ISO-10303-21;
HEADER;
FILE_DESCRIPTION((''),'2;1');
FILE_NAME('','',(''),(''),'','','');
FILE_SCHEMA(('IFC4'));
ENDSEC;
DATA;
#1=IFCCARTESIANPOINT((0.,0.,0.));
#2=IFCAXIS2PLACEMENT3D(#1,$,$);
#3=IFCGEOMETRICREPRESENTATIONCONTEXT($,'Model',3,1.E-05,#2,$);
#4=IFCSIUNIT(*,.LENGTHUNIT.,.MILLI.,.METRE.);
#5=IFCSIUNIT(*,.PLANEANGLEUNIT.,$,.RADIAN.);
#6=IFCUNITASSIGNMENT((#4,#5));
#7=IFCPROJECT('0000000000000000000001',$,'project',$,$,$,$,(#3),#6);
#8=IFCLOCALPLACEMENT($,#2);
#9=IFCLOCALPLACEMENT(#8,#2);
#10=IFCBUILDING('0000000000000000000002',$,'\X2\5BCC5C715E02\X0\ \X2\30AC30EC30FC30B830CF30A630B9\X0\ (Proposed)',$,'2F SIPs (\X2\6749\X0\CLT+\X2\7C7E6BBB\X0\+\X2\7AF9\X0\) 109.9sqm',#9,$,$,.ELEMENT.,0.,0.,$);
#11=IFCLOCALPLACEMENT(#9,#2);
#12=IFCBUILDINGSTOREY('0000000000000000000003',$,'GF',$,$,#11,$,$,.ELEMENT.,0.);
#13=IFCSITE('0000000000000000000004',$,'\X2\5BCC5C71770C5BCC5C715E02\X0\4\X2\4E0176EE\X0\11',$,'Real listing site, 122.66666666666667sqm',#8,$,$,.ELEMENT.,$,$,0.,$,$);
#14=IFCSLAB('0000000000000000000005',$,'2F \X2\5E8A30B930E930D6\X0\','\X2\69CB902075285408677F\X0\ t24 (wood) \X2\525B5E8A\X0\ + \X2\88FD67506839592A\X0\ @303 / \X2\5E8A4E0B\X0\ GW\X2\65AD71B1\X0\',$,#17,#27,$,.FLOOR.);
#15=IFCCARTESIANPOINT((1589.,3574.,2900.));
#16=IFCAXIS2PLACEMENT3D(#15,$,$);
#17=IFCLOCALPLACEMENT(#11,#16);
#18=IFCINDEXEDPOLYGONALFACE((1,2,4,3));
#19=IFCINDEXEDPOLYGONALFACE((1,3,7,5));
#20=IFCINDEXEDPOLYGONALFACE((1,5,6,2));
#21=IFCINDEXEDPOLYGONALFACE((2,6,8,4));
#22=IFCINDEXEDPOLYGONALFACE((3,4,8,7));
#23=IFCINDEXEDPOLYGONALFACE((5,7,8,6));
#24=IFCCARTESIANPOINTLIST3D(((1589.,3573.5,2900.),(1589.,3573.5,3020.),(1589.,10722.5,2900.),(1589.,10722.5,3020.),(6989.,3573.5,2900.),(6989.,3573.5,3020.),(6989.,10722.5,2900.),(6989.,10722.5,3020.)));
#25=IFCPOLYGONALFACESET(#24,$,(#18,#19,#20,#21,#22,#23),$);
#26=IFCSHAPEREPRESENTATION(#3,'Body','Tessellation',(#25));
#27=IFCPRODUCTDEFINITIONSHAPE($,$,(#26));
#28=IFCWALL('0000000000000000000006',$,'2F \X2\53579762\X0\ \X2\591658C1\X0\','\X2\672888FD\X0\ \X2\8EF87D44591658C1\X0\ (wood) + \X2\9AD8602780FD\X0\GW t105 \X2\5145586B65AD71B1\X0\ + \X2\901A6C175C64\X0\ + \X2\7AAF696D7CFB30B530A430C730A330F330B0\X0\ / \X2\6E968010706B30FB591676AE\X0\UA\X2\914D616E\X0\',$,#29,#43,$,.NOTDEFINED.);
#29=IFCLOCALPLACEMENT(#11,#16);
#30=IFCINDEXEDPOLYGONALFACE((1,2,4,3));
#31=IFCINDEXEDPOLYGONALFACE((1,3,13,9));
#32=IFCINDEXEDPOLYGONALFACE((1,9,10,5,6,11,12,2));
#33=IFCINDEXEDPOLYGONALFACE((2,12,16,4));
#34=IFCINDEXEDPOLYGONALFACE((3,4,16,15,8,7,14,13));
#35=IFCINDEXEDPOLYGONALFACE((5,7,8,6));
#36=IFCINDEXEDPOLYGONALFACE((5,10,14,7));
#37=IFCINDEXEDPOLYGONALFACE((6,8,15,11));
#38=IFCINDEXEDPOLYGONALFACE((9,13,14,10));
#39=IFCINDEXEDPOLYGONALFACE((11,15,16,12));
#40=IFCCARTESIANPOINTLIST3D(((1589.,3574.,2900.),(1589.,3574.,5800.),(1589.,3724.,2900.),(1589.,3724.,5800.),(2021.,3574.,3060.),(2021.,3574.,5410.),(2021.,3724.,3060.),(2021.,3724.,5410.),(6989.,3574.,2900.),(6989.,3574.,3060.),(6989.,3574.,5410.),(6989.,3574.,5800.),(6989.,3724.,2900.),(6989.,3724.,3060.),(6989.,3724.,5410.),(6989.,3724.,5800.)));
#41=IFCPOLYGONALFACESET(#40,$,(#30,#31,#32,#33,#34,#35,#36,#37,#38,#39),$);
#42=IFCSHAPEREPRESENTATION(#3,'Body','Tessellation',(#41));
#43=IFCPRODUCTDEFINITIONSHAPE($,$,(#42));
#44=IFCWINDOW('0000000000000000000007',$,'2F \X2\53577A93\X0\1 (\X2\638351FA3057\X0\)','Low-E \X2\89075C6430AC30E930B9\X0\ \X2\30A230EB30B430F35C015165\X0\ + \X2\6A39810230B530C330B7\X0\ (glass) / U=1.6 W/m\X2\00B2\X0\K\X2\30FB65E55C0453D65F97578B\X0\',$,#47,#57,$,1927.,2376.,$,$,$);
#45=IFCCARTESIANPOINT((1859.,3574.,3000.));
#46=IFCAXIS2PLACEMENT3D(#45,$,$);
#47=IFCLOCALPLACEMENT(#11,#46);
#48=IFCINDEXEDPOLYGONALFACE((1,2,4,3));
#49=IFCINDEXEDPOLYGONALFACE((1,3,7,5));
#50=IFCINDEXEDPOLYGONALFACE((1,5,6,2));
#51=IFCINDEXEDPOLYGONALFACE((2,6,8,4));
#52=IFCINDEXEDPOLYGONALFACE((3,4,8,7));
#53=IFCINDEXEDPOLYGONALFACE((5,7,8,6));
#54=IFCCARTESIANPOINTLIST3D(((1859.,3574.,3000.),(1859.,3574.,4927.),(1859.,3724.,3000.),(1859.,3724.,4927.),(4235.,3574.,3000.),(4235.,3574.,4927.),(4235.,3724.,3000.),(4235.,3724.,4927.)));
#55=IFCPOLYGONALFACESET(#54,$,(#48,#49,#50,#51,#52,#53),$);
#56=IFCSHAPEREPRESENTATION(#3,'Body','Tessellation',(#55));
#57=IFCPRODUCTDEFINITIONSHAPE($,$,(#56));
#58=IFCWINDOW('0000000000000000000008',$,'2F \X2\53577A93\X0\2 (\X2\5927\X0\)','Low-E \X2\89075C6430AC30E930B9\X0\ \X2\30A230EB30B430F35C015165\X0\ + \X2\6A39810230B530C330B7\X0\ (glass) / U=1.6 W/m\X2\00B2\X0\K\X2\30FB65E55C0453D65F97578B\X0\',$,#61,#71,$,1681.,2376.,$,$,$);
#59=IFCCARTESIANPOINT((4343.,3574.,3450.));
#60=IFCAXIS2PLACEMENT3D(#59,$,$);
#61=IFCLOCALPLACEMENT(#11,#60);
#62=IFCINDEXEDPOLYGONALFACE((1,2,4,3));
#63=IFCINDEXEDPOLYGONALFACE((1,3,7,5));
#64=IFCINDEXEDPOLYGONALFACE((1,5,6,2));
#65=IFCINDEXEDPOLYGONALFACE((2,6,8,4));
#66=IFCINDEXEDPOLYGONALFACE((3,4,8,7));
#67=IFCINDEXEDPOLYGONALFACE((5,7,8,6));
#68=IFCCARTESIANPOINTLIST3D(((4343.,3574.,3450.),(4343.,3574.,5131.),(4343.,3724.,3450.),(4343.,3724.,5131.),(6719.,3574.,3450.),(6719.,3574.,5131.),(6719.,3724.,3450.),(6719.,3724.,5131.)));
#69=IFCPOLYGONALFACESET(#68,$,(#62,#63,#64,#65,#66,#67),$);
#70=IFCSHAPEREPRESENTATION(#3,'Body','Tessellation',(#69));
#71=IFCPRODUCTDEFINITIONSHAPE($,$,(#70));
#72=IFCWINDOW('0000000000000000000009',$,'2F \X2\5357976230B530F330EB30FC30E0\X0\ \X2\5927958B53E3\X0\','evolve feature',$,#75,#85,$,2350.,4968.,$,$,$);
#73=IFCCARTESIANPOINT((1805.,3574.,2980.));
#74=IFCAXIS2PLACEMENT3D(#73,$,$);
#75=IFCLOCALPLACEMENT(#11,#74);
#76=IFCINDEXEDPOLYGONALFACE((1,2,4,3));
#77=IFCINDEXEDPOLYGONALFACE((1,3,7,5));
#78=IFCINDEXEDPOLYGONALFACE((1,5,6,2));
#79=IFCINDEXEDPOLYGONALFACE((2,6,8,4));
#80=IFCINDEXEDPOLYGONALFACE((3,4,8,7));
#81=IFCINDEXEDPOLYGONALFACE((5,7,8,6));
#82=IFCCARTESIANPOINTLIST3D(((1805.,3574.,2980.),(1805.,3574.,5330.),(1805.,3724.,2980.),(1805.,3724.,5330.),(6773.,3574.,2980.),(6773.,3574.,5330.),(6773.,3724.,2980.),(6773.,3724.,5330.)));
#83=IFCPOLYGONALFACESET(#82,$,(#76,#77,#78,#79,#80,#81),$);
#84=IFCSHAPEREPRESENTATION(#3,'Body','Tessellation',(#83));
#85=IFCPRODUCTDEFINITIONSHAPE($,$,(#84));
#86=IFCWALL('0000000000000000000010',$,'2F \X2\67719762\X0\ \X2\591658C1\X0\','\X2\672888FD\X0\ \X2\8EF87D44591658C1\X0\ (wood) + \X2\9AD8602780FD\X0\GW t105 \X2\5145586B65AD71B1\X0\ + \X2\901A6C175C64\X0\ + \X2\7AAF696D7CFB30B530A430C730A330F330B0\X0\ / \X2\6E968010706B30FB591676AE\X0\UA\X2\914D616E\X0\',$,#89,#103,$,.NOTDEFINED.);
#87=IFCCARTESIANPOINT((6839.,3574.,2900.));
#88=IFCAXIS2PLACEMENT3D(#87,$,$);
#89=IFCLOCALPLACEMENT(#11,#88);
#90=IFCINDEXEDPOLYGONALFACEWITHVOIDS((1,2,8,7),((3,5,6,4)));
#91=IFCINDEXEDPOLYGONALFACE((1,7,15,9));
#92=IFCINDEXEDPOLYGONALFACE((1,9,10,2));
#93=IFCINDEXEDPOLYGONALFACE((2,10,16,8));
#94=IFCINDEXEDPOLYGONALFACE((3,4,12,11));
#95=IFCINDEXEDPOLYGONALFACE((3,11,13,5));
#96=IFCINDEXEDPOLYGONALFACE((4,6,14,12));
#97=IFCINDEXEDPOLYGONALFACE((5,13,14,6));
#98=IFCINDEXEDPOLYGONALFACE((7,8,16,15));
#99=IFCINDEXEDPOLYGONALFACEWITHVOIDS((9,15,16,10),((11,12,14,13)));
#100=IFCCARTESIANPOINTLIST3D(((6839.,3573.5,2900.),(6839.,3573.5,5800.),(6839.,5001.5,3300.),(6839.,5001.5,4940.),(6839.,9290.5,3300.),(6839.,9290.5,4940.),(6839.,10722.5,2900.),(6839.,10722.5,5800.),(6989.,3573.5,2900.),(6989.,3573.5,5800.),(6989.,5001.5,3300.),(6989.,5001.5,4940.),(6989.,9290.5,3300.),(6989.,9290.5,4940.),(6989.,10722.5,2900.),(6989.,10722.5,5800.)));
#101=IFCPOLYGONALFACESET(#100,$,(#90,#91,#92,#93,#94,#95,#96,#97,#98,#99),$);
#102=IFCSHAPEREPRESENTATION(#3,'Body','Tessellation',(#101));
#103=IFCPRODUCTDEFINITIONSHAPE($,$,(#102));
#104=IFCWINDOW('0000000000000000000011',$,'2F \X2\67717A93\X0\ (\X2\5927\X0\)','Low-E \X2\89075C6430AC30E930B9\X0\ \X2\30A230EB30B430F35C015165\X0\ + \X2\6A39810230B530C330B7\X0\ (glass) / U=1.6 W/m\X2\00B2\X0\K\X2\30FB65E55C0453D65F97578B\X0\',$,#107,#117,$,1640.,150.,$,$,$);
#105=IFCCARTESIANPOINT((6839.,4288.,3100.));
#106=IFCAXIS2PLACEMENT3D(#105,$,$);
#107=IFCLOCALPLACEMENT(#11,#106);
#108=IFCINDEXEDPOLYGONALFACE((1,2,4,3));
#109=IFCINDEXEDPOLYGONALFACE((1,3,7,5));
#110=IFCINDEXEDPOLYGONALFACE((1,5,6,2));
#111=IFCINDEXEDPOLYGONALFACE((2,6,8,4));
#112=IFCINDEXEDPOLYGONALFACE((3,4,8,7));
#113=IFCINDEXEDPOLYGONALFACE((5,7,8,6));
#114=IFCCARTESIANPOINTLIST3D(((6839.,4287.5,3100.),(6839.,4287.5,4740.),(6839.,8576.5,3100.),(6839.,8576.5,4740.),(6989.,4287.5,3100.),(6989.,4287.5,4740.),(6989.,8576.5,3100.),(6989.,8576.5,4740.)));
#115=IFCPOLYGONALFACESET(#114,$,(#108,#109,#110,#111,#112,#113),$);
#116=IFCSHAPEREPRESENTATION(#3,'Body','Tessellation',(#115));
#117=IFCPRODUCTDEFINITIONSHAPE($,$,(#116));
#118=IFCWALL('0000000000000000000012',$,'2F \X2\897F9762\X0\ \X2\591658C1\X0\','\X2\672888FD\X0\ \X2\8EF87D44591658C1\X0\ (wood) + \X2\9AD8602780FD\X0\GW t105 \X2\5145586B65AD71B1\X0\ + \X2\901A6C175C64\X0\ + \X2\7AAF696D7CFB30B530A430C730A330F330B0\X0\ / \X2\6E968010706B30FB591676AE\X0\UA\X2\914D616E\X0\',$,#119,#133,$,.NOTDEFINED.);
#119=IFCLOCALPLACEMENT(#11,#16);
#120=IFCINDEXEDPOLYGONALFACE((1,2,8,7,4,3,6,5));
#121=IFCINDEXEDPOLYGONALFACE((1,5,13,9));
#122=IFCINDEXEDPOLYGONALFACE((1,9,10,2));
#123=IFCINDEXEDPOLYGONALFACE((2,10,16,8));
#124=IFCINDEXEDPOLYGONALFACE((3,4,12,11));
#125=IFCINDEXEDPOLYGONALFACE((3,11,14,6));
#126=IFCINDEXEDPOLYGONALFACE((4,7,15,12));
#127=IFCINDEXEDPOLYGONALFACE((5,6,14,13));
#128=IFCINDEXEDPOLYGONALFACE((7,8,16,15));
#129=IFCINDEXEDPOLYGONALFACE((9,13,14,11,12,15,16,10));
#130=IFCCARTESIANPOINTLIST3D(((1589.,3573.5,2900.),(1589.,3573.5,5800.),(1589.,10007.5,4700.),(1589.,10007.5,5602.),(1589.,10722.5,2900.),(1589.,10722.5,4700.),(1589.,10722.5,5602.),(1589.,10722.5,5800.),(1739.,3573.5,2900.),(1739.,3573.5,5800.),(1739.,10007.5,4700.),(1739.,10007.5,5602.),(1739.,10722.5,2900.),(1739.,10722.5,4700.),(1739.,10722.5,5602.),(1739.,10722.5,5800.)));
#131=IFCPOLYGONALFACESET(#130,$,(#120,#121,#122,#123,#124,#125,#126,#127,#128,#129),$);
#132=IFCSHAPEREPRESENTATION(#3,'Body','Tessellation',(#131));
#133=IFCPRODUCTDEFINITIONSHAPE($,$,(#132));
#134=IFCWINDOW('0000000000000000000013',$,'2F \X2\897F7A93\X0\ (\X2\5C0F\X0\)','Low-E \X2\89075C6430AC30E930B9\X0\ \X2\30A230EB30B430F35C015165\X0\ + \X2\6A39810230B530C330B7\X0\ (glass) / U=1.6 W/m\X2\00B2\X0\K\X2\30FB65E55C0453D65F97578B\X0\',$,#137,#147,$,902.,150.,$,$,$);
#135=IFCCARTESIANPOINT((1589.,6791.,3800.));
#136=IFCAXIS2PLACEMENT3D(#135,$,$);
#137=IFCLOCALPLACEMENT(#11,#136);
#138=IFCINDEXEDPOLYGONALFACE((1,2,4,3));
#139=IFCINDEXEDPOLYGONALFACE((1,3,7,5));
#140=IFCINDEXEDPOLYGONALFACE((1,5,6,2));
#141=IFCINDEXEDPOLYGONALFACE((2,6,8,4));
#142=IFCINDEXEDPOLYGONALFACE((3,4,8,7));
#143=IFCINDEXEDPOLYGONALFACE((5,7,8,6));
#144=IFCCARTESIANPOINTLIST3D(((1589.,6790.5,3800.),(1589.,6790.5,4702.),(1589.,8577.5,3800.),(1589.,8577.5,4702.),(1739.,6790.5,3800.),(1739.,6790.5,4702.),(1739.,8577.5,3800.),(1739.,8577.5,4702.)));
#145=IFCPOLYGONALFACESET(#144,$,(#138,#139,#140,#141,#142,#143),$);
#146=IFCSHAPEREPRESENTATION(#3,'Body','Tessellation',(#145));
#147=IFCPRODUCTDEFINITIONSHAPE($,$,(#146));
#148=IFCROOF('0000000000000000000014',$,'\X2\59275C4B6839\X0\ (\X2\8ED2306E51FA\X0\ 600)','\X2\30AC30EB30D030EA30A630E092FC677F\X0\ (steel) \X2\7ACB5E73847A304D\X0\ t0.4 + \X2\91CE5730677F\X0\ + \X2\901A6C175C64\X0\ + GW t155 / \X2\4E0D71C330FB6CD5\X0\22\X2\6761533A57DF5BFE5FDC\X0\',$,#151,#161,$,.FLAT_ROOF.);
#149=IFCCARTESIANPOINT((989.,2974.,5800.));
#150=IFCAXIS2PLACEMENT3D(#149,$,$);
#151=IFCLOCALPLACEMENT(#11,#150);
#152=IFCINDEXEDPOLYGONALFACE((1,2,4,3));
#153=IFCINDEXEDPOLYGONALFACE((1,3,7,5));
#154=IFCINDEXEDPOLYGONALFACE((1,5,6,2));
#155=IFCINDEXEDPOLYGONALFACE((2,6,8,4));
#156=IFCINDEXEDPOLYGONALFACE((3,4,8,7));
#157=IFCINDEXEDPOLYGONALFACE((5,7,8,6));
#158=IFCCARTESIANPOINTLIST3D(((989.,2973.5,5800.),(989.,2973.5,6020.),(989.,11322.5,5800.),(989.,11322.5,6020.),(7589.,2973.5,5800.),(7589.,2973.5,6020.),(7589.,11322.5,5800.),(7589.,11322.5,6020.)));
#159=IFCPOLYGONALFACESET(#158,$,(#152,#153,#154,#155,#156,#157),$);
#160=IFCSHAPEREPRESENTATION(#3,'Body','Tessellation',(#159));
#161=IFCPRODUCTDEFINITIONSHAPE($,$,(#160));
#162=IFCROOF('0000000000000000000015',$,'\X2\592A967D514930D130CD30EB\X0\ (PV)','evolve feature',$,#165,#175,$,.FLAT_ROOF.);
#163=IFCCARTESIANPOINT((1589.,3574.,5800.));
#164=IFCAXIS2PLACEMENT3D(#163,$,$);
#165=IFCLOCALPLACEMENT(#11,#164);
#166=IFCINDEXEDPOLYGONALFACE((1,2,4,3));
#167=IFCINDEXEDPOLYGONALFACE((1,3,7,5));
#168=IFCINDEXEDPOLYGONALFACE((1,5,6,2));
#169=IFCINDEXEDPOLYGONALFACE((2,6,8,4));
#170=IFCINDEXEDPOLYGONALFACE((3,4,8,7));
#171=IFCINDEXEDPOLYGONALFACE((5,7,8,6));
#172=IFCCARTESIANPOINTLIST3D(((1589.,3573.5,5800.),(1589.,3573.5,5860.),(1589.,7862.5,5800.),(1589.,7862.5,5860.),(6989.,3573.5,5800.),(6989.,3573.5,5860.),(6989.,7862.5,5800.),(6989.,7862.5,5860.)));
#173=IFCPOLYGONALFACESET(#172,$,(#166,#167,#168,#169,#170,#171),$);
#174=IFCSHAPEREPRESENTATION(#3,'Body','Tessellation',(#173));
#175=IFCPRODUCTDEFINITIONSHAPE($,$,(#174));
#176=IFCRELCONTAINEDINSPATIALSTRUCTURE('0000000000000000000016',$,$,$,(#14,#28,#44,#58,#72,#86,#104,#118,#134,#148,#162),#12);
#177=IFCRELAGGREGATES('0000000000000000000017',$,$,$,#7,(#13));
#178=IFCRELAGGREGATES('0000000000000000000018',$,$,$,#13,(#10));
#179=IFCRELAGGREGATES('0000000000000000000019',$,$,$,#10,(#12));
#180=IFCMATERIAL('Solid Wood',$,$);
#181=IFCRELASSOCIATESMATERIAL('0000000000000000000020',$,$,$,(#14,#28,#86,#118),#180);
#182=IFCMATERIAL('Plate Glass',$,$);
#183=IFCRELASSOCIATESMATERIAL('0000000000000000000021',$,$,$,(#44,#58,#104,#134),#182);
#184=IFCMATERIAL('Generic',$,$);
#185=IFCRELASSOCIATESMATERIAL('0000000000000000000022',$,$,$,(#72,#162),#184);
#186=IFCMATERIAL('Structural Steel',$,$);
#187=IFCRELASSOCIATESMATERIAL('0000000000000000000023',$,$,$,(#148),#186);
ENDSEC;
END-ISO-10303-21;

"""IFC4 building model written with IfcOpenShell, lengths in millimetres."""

from ifc_helpers import new_model, si_unit, frame, frame_2d, origin, place, context, project, spatial, rectangle, extrude, material, element, fill, save


model = new_model("IFC4")

# Units and contexts
model_context = context("Model", 3, precision=1e-05, world=origin())
ifc_project = project(units=[si_unit("LENGTHUNIT", "METRE", prefix="MILLI"), si_unit("PLANEANGLEUNIT", "RADIAN")], contexts=[model_context])

# Site, building, storey
site_placement = place(None, origin())
site = spatial("IfcSite", under=ifc_project, at=site_placement, Name="富山県富山市4丁目11", ObjectType="Real listing site, 122.66666666666667sqm", CompositionType="ELEMENT", RefElevation=0.0)
building_placement = place(site_placement, origin())
building = spatial("IfcBuilding", under=site, at=building_placement, Name="富山市 ガレージハウス (Proposed)", ObjectType="2F SIPs (杉CLT+籾殻+竹) 109.9sqm", CompositionType="ELEMENT", ElevationOfRefHeight=0.0, ElevationOfTerrain=0.0)
storey_placement = place(building_placement, origin())
storey = spatial("IfcBuildingStorey", under=building, at=storey_placement, Name="GF", CompositionType="ELEMENT", Elevation=0.0)

# Slab
ifc_material_1 = material(Name="Solid Wood")
slab_placement = place(storey_placement, frame((1589.0, 3574.0, 2900.0)))
element("IfcSlab", 1, at=slab_placement, inside=storey, material=ifc_material_1, Name="2F 床スラブ", Description="構造用合板 t24 (wood) 剛床 + 製材根太 @303 / 床下 GW断熱", PredefinedType="FLOOR", context=model_context, shape_type="SweptSolid", body=[
    extrude(rectangle(XDim=5400.0, YDim=7149.0, at=frame_2d((2700.0, 3574.0))), frame((1589.0, 3574.0, 2900.0)), (0.0, 0.0, 1.0), 120.0),
])

# Wall, openings, windows
wall_1_placement = place(storey_placement, frame((1589.0, 3574.0, 2900.0)))
wall_1 = element("IfcWall", 2, at=wall_1_placement, inside=storey, material=ifc_material_1, Name="2F 南面 外壁", Description="木製 軸組外壁 (wood) + 高性能GW t105 充填断熱 + 通気層 + 窯業系サイディング / 準耐火・外皮UA配慮", PredefinedType="NOTDEFINED", context=model_context, shape_type="SweptSolid", body=[
    extrude(rectangle(XDim=5400.0, YDim=150.0, at=frame_2d((2700.0, 75.0))), frame((1589.0, 3574.0, 2900.0)), (0.0, 0.0, 1.0), 2900.0),
])
opening_1_placement = place(storey_placement, frame((1859.0, 3574.0, 3000.0)))
opening_1 = element("IfcOpeningElement", 3, at=opening_1_placement, cuts=wall_1, PredefinedType="NOTDEFINED", context=model_context, shape_type="SweptSolid", body=[
    extrude(rectangle(XDim=2376.0, YDim=150.0, at=frame_2d((1188.0, 75.0))), frame((1859.0, 3574.0, 3000.0)), (0.0, 0.0, 1.0), 1927.0),
])
opening_2_placement = place(storey_placement, frame((4343.0, 3574.0, 3450.0)))
opening_2 = element("IfcOpeningElement", 4, at=opening_2_placement, cuts=wall_1, PredefinedType="NOTDEFINED", context=model_context, shape_type="SweptSolid", body=[
    extrude(rectangle(XDim=2376.0, YDim=150.0, at=frame_2d((1188.0, 75.0))), frame((4343.0, 3574.0, 3450.0)), (0.0, 0.0, 1.0), 1681.0),
])
opening_3_placement = place(storey_placement, frame((1805.0, 3574.0, 2980.0)))
opening_3 = element("IfcOpeningElement", 5, at=opening_3_placement, cuts=wall_1, PredefinedType="NOTDEFINED", context=model_context, shape_type="SweptSolid", body=[
    extrude(rectangle(XDim=4968.0, YDim=150.0, at=frame_2d((2484.0, 75.0))), frame((1805.0, 3574.0, 2980.0)), (0.0, 0.0, 1.0), 2350.0),
])
ifc_material_2 = material(Name="Plate Glass")
window_1_placement = place(storey_placement, frame((1859.0, 3574.0, 3000.0)))
window_1 = element("IfcWindow", 6, at=window_1_placement, inside=storey, material=ifc_material_2, Name="2F 南窓1 (掃出し)", Description="Low-E 複層ガラス アルゴン封入 + 樹脂サッシ (glass) / U=1.6 W/m²K・日射取得型", OverallHeight=1927.0, OverallWidth=2376.0, context=model_context, shape_type="SweptSolid", body=[
    extrude(rectangle(XDim=2376.0, YDim=150.0, at=frame_2d((1188.0, 75.0))), frame((1859.0, 3574.0, 3000.0)), (0.0, 0.0, 1.0), 1927.0),
])
fill(opening_1, window_1)
window_2_placement = place(storey_placement, frame((4343.0, 3574.0, 3450.0)))
window_2 = element("IfcWindow", 7, at=window_2_placement, inside=storey, material=ifc_material_2, Name="2F 南窓2 (大)", Description="Low-E 複層ガラス アルゴン封入 + 樹脂サッシ (glass) / U=1.6 W/m²K・日射取得型", OverallHeight=1681.0, OverallWidth=2376.0, context=model_context, shape_type="SweptSolid", body=[
    extrude(rectangle(XDim=2376.0, YDim=150.0, at=frame_2d((1188.0, 75.0))), frame((4343.0, 3574.0, 3450.0)), (0.0, 0.0, 1.0), 1681.0),
])
fill(opening_2, window_2)
ifc_material_3 = material(Name="Generic")
window_3_placement = place(storey_placement, frame((1805.0, 3574.0, 2980.0)))
window_3 = element("IfcWindow", 8, at=window_3_placement, inside=storey, material=ifc_material_3, Name="2F 南面サンルーム 大開口", Description="evolve feature", OverallHeight=2350.0, OverallWidth=4968.0, context=model_context, shape_type="SweptSolid", body=[
    extrude(rectangle(XDim=4968.0, YDim=150.0, at=frame_2d((2484.0, 75.0))), frame((1805.0, 3574.0, 2980.0)), (0.0, 0.0, 1.0), 2350.0),
])
fill(opening_3, window_3)

# Walls, openings, windows
wall_2_placement = place(storey_placement, frame((6839.0, 3574.0, 2900.0)))
wall_2 = element("IfcWall", 9, at=wall_2_placement, inside=storey, material=ifc_material_1, Name="2F 東面 外壁", Description="木製 軸組外壁 (wood) + 高性能GW t105 充填断熱 + 通気層 + 窯業系サイディング / 準耐火・外皮UA配慮", PredefinedType="NOTDEFINED", context=model_context, shape_type="SweptSolid", body=[
    extrude(rectangle(XDim=150.0, YDim=7149.0, at=frame_2d((75.0, 3574.0))), frame((6839.0, 3574.0, 2900.0)), (0.0, 0.0, 1.0), 2900.0),
])
opening_4_placement = place(storey_placement, frame((6839.0, 4288.0, 3100.0)))
opening_4 = element("IfcOpeningElement", 10, at=opening_4_placement, cuts=wall_2, PredefinedType="NOTDEFINED", context=model_context, shape_type="SweptSolid", body=[
    extrude(rectangle(XDim=150.0, YDim=4289.0, at=frame_2d((75.0, 2144.0))), frame((6839.0, 4288.0, 3100.0)), (0.0, 0.0, 1.0), 1640.0),
])
window_4_placement = place(storey_placement, frame((6839.0, 4288.0, 3100.0)))
window_4 = element("IfcWindow", 11, at=window_4_placement, inside=storey, material=ifc_material_2, Name="2F 東窓 (大)", Description="Low-E 複層ガラス アルゴン封入 + 樹脂サッシ (glass) / U=1.6 W/m²K・日射取得型", OverallHeight=1640.0, OverallWidth=150.0, context=model_context, shape_type="SweptSolid", body=[
    extrude(rectangle(XDim=150.0, YDim=4289.0, at=frame_2d((75.0, 2144.0))), frame((6839.0, 4288.0, 3100.0)), (0.0, 0.0, 1.0), 1640.0),
])
fill(opening_4, window_4)
wall_3_placement = place(storey_placement, frame((1589.0, 3574.0, 2900.0)))
wall_3 = element("IfcWall", 12, at=wall_3_placement, inside=storey, material=ifc_material_1, Name="2F 西面 外壁", Description="木製 軸組外壁 (wood) + 高性能GW t105 充填断熱 + 通気層 + 窯業系サイディング / 準耐火・外皮UA配慮", PredefinedType="NOTDEFINED", context=model_context, shape_type="SweptSolid", body=[
    extrude(rectangle(XDim=150.0, YDim=7149.0, at=frame_2d((75.0, 3574.0))), frame((1589.0, 3574.0, 2900.0)), (0.0, 0.0, 1.0), 2900.0),
])
opening_5_placement = place(storey_placement, frame((1589.0, 6791.0, 3800.0)))
opening_5 = element("IfcOpeningElement", 13, at=opening_5_placement, cuts=wall_3, PredefinedType="NOTDEFINED", context=model_context, shape_type="SweptSolid", body=[
    extrude(rectangle(XDim=150.0, YDim=1787.0, at=frame_2d((75.0, 893.0))), frame((1589.0, 6791.0, 3800.0)), (0.0, 0.0, 1.0), 902.0),
])
window_5_placement = place(storey_placement, frame((1589.0, 6791.0, 3800.0)))
window_5 = element("IfcWindow", 14, at=window_5_placement, inside=storey, material=ifc_material_2, Name="2F 西窓 (小)", Description="Low-E 複層ガラス アルゴン封入 + 樹脂サッシ (glass) / U=1.6 W/m²K・日射取得型", OverallHeight=902.0, OverallWidth=150.0, context=model_context, shape_type="SweptSolid", body=[
    extrude(rectangle(XDim=150.0, YDim=1787.0, at=frame_2d((75.0, 893.0))), frame((1589.0, 6791.0, 3800.0)), (0.0, 0.0, 1.0), 902.0),
])
fill(opening_5, window_5)

# Roofs
ifc_material_4 = material(Name="Structural Steel")
roof_1_placement = place(storey_placement, frame((989.0, 2974.0, 5800.0)))
element("IfcRoof", 15, at=roof_1_placement, inside=storey, material=ifc_material_4, Name="大屋根 (軒の出 600)", Description="ガルバリウム鋼板 (steel) 立平葺き t0.4 + 野地板 + 通気層 + GW t155 / 不燃・法22条区域対応", PredefinedType="FLAT_ROOF", context=model_context, shape_type="SweptSolid", body=[
    extrude(rectangle(XDim=6600.0, YDim=8349.0, at=frame_2d((3300.0, 4174.0))), frame((989.0, 2974.0, 5800.0)), (0.0, 0.0, 1.0), 220.0),
])
roof_2_placement = place(storey_placement, frame((1589.0, 3574.0, 5800.0)))
element("IfcRoof", 16, at=roof_2_placement, inside=storey, material=ifc_material_3, Name="太陽光パネル (PV)", Description="evolve feature", PredefinedType="FLAT_ROOF", context=model_context, shape_type="SweptSolid", body=[
    extrude(rectangle(XDim=5400.0, YDim=4289.0, at=frame_2d((2700.0, 2144.0))), frame((1589.0, 3574.0, 5800.0)), (0.0, 0.0, 1.0), 60.0),
])

save(model, "model.ifc")
